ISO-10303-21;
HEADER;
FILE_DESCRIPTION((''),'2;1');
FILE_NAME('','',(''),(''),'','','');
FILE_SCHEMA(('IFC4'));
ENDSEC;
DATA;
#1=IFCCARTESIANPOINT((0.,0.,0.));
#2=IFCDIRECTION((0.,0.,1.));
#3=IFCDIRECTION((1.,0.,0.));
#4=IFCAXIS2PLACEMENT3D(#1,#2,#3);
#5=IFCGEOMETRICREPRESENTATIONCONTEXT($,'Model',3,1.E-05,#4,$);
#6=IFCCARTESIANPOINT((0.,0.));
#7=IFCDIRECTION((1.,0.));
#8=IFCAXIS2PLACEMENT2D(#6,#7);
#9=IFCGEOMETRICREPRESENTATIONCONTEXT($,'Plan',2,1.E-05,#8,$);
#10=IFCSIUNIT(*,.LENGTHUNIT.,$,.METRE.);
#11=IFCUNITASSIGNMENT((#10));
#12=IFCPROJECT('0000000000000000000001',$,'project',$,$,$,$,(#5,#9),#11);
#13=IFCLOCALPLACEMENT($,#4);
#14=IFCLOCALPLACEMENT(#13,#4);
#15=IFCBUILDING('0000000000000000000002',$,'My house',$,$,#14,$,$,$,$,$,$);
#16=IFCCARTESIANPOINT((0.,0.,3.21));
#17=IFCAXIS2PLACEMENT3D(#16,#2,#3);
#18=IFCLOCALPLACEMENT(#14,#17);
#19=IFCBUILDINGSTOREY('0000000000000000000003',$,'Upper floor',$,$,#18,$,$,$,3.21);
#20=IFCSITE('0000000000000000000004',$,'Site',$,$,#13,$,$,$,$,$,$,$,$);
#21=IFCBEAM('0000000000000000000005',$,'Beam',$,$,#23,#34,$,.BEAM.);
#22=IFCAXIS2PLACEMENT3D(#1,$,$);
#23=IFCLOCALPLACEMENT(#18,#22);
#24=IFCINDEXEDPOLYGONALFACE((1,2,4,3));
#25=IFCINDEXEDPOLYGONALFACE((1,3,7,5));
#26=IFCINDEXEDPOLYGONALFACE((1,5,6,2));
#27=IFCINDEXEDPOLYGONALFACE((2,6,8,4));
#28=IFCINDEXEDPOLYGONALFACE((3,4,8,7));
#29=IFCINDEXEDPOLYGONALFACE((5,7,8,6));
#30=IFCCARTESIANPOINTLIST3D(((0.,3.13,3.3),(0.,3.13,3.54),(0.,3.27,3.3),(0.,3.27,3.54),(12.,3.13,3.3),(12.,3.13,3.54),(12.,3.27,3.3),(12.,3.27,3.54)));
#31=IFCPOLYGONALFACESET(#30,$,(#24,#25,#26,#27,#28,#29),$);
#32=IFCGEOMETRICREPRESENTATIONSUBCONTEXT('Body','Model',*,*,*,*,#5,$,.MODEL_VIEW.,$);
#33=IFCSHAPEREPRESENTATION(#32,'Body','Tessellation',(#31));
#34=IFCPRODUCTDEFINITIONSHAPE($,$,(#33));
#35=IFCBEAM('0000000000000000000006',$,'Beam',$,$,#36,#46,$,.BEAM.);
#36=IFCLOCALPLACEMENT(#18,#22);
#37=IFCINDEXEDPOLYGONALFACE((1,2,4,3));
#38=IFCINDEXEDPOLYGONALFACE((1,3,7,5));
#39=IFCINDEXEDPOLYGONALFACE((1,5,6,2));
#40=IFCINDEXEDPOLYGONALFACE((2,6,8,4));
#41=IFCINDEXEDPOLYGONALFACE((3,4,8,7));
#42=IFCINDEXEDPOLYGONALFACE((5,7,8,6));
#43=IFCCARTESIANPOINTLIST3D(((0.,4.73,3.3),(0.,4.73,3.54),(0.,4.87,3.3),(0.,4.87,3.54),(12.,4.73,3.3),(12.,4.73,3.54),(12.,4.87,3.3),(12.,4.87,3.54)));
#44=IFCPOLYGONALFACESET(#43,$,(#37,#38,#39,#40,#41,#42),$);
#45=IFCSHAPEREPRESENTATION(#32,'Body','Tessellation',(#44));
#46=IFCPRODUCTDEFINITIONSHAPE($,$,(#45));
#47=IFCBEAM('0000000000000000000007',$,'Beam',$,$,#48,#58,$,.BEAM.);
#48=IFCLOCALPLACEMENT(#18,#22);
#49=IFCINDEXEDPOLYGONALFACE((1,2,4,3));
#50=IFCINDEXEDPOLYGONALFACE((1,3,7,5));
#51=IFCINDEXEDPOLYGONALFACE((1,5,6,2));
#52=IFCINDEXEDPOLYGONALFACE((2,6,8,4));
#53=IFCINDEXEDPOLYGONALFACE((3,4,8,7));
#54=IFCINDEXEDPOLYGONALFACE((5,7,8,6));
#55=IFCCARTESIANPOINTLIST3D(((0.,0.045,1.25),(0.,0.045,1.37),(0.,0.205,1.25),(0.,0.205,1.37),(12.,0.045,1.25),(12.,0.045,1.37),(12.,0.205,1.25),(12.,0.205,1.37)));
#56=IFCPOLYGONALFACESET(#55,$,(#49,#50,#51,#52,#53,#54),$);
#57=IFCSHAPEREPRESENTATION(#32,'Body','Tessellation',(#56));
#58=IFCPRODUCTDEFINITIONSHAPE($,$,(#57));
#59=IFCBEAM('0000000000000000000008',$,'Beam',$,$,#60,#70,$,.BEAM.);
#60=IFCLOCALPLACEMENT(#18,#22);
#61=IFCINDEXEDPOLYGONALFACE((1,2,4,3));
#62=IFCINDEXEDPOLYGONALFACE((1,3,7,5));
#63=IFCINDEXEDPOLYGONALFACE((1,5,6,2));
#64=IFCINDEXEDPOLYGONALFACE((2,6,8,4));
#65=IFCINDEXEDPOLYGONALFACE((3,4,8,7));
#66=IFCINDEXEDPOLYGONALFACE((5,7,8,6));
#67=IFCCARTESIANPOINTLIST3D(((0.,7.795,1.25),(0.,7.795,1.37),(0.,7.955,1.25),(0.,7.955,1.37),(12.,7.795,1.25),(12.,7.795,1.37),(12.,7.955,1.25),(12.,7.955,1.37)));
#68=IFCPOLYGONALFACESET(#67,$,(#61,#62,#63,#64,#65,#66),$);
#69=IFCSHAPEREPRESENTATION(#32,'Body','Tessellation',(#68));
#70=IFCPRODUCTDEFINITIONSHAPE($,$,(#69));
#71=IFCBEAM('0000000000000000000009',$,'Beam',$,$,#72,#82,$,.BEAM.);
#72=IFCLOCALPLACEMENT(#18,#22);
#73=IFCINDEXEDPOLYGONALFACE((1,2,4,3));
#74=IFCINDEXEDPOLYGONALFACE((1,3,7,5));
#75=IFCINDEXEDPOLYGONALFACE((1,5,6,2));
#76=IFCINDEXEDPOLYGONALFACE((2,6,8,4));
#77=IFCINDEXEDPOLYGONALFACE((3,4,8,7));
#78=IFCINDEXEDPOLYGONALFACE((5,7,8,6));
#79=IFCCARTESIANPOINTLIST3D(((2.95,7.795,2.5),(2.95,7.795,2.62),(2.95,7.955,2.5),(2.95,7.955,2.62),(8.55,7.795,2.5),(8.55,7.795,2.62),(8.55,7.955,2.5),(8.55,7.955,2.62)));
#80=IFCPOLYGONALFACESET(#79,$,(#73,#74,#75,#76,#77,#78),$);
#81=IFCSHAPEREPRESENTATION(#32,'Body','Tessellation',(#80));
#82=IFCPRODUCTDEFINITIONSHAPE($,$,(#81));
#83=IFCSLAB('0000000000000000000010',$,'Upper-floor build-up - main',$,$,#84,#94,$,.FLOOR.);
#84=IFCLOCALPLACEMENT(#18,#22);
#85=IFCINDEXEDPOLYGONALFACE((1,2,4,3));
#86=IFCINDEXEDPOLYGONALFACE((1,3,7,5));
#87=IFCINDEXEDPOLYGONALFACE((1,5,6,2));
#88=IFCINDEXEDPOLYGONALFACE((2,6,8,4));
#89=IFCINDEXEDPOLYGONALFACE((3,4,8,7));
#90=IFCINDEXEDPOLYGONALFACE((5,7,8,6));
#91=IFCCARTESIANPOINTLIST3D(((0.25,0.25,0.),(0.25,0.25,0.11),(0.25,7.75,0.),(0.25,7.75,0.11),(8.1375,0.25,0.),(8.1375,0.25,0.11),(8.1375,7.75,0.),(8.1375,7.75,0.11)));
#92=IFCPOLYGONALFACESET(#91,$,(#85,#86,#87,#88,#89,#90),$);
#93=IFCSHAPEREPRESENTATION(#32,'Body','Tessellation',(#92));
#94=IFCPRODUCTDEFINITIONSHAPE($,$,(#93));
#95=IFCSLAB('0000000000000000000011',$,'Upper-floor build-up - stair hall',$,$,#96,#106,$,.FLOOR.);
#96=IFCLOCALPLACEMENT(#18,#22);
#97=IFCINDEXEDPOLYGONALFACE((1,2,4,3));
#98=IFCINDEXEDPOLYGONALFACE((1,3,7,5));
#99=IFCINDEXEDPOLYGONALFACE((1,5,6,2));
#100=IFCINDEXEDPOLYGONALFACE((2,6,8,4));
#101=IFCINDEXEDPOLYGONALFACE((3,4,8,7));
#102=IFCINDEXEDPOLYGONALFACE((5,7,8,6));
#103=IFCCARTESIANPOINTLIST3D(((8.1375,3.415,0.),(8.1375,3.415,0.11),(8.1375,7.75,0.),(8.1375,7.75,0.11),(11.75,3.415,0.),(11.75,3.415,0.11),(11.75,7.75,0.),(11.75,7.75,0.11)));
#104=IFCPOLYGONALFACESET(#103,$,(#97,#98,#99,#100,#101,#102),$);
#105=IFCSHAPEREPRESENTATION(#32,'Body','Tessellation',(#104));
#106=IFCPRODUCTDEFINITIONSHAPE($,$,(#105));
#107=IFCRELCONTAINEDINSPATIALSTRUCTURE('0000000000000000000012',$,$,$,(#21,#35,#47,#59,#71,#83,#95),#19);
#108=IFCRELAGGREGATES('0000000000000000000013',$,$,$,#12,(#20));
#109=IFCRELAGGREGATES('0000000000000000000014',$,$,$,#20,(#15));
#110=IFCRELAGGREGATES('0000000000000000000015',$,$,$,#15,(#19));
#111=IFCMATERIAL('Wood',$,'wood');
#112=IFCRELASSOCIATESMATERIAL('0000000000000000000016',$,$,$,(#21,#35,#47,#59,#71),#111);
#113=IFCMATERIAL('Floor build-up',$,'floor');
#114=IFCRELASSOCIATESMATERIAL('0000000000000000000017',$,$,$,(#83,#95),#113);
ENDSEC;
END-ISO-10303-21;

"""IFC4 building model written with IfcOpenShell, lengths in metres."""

from ifc_helpers import new_model, si_unit, frame, origin_with_axes, origin_2d_with_axis, place, context, subcontext, project, spatial, indexed_curve, rectangle, outline, extrude, material, element, save


model = new_model("IFC4")

# Units and contexts
model_context = context("Model", 3, precision=1e-05, world=origin_with_axes())
plan_context = context("Plan", 2, precision=1e-05, world=origin_2d_with_axis())
body_context_1 = subcontext(model_context, "Body", "Model", "MODEL_VIEW")
ifc_project = project(units=[si_unit("LENGTHUNIT", "METRE")], contexts=[model_context, plan_context])

# Site, building, storey
site_placement = place(None, origin_with_axes())
site = spatial("IfcSite", under=ifc_project, at=site_placement, Name="Site")
building_placement = place(site_placement, origin_with_axes())
building = spatial("IfcBuilding", under=site, at=building_placement, Name="My house")
storey_placement = place(building_placement, frame((0.0, 0.0, 3.21), z_axis=(0.0, 0.0, 1.0), x_axis=(1.0, 0.0, 0.0)))
storey = spatial("IfcBuildingStorey", under=building, at=storey_placement, Name="Upper floor", Elevation=3.21)

# Beams
ifc_material_1 = material(Name="Wood", Category="wood")
for number, where, z_axis, x_axis, name in (
    (1, (0.0, 3.2, 3.42), (0.0, 0.0, 1.0), (1.0, 0.0, 0.0), "Beam"),
    (2, (0.0, 4.8, 3.42), (0.0, 0.0, 1.0), (1.0, 0.0, 0.0), "Beam"),
):
    element("IfcBeam", number, at=place(storey_placement, frame(where, z_axis=z_axis, x_axis=x_axis)), inside=storey, material=ifc_material_1, Name=name, PredefinedType="BEAM", context=body_context_1, shape_type="SweptSolid", body=[
        extrude(rectangle(XDim=0.14, YDim=0.24), frame((0.0, 0.0, 0.0), z_axis=(1.0, 0.0, 0.0), x_axis=(0.0, 1.0, 0.0)), (0.0, 0.0, 1.0), 12.0),
    ])
for number, where, z_axis, x_axis, name in (
    (3, (0.0, 0.125, 1.31), (0.0, 0.0, 1.0), (1.0, 0.0, 0.0), "Beam"),
    (4, (0.0, 7.875, 1.31), (0.0, 0.0, 1.0), (1.0, 0.0, 0.0), "Beam"),
):
    element("IfcBeam", number, at=place(storey_placement, frame(where, z_axis=z_axis, x_axis=x_axis)), inside=storey, material=ifc_material_1, Name=name, PredefinedType="BEAM", context=body_context_1, shape_type="SweptSolid", body=[
        extrude(rectangle(XDim=0.16, YDim=0.12), frame((0.0, 0.0, 0.0), z_axis=(1.0, 0.0, 0.0), x_axis=(0.0, 1.0, 0.0)), (0.0, 0.0, 1.0), 12.0),
    ])
beam_placement = place(storey_placement, frame((8.55, 7.875, 2.56), z_axis=(0.0, 0.0, 1.0), x_axis=(-1.0, 0.0, 0.0)))
element("IfcBeam", 5, at=beam_placement, inside=storey, material=ifc_material_1, Name="Beam", PredefinedType="BEAM", context=body_context_1, shape_type="SweptSolid", body=[
    extrude(rectangle(XDim=0.16, YDim=0.12), frame((0.0, 0.0, 0.0), z_axis=(1.0, 0.0, 0.0), x_axis=(0.0, 1.0, 0.0)), (0.0, 0.0, 1.0), 5.6),
])

# Slabs
ifc_material_2 = material(Name="Floor build-up", Category="floor")
slab_1_placement = place(storey_placement, origin_with_axes())
element("IfcSlab", 6, at=slab_1_placement, inside=storey, material=ifc_material_2, Name="Upper-floor build-up - main", PredefinedType="FLOOR", context=body_context_1, shape_type="SweptSolid", body=[
    extrude(outline(indexed_curve([(0.25, 0.25), (8.1375, 0.25), (8.1375, 7.75), (0.25, 7.75)])), None, (0.0, 0.0, 1.0), 0.11),
])
slab_2_placement = place(storey_placement, origin_with_axes())
element("IfcSlab", 7, at=slab_2_placement, inside=storey, material=ifc_material_2, Name="Upper-floor build-up - stair hall", PredefinedType="FLOOR", context=body_context_1, shape_type="SweptSolid", body=[
    extrude(outline(indexed_curve([(8.1375, 3.415), (11.75, 3.415), (11.75, 7.75), (8.1375, 7.75)])), None, (0.0, 0.0, 1.0), 0.11),
])

save(model, "model.ifc")
